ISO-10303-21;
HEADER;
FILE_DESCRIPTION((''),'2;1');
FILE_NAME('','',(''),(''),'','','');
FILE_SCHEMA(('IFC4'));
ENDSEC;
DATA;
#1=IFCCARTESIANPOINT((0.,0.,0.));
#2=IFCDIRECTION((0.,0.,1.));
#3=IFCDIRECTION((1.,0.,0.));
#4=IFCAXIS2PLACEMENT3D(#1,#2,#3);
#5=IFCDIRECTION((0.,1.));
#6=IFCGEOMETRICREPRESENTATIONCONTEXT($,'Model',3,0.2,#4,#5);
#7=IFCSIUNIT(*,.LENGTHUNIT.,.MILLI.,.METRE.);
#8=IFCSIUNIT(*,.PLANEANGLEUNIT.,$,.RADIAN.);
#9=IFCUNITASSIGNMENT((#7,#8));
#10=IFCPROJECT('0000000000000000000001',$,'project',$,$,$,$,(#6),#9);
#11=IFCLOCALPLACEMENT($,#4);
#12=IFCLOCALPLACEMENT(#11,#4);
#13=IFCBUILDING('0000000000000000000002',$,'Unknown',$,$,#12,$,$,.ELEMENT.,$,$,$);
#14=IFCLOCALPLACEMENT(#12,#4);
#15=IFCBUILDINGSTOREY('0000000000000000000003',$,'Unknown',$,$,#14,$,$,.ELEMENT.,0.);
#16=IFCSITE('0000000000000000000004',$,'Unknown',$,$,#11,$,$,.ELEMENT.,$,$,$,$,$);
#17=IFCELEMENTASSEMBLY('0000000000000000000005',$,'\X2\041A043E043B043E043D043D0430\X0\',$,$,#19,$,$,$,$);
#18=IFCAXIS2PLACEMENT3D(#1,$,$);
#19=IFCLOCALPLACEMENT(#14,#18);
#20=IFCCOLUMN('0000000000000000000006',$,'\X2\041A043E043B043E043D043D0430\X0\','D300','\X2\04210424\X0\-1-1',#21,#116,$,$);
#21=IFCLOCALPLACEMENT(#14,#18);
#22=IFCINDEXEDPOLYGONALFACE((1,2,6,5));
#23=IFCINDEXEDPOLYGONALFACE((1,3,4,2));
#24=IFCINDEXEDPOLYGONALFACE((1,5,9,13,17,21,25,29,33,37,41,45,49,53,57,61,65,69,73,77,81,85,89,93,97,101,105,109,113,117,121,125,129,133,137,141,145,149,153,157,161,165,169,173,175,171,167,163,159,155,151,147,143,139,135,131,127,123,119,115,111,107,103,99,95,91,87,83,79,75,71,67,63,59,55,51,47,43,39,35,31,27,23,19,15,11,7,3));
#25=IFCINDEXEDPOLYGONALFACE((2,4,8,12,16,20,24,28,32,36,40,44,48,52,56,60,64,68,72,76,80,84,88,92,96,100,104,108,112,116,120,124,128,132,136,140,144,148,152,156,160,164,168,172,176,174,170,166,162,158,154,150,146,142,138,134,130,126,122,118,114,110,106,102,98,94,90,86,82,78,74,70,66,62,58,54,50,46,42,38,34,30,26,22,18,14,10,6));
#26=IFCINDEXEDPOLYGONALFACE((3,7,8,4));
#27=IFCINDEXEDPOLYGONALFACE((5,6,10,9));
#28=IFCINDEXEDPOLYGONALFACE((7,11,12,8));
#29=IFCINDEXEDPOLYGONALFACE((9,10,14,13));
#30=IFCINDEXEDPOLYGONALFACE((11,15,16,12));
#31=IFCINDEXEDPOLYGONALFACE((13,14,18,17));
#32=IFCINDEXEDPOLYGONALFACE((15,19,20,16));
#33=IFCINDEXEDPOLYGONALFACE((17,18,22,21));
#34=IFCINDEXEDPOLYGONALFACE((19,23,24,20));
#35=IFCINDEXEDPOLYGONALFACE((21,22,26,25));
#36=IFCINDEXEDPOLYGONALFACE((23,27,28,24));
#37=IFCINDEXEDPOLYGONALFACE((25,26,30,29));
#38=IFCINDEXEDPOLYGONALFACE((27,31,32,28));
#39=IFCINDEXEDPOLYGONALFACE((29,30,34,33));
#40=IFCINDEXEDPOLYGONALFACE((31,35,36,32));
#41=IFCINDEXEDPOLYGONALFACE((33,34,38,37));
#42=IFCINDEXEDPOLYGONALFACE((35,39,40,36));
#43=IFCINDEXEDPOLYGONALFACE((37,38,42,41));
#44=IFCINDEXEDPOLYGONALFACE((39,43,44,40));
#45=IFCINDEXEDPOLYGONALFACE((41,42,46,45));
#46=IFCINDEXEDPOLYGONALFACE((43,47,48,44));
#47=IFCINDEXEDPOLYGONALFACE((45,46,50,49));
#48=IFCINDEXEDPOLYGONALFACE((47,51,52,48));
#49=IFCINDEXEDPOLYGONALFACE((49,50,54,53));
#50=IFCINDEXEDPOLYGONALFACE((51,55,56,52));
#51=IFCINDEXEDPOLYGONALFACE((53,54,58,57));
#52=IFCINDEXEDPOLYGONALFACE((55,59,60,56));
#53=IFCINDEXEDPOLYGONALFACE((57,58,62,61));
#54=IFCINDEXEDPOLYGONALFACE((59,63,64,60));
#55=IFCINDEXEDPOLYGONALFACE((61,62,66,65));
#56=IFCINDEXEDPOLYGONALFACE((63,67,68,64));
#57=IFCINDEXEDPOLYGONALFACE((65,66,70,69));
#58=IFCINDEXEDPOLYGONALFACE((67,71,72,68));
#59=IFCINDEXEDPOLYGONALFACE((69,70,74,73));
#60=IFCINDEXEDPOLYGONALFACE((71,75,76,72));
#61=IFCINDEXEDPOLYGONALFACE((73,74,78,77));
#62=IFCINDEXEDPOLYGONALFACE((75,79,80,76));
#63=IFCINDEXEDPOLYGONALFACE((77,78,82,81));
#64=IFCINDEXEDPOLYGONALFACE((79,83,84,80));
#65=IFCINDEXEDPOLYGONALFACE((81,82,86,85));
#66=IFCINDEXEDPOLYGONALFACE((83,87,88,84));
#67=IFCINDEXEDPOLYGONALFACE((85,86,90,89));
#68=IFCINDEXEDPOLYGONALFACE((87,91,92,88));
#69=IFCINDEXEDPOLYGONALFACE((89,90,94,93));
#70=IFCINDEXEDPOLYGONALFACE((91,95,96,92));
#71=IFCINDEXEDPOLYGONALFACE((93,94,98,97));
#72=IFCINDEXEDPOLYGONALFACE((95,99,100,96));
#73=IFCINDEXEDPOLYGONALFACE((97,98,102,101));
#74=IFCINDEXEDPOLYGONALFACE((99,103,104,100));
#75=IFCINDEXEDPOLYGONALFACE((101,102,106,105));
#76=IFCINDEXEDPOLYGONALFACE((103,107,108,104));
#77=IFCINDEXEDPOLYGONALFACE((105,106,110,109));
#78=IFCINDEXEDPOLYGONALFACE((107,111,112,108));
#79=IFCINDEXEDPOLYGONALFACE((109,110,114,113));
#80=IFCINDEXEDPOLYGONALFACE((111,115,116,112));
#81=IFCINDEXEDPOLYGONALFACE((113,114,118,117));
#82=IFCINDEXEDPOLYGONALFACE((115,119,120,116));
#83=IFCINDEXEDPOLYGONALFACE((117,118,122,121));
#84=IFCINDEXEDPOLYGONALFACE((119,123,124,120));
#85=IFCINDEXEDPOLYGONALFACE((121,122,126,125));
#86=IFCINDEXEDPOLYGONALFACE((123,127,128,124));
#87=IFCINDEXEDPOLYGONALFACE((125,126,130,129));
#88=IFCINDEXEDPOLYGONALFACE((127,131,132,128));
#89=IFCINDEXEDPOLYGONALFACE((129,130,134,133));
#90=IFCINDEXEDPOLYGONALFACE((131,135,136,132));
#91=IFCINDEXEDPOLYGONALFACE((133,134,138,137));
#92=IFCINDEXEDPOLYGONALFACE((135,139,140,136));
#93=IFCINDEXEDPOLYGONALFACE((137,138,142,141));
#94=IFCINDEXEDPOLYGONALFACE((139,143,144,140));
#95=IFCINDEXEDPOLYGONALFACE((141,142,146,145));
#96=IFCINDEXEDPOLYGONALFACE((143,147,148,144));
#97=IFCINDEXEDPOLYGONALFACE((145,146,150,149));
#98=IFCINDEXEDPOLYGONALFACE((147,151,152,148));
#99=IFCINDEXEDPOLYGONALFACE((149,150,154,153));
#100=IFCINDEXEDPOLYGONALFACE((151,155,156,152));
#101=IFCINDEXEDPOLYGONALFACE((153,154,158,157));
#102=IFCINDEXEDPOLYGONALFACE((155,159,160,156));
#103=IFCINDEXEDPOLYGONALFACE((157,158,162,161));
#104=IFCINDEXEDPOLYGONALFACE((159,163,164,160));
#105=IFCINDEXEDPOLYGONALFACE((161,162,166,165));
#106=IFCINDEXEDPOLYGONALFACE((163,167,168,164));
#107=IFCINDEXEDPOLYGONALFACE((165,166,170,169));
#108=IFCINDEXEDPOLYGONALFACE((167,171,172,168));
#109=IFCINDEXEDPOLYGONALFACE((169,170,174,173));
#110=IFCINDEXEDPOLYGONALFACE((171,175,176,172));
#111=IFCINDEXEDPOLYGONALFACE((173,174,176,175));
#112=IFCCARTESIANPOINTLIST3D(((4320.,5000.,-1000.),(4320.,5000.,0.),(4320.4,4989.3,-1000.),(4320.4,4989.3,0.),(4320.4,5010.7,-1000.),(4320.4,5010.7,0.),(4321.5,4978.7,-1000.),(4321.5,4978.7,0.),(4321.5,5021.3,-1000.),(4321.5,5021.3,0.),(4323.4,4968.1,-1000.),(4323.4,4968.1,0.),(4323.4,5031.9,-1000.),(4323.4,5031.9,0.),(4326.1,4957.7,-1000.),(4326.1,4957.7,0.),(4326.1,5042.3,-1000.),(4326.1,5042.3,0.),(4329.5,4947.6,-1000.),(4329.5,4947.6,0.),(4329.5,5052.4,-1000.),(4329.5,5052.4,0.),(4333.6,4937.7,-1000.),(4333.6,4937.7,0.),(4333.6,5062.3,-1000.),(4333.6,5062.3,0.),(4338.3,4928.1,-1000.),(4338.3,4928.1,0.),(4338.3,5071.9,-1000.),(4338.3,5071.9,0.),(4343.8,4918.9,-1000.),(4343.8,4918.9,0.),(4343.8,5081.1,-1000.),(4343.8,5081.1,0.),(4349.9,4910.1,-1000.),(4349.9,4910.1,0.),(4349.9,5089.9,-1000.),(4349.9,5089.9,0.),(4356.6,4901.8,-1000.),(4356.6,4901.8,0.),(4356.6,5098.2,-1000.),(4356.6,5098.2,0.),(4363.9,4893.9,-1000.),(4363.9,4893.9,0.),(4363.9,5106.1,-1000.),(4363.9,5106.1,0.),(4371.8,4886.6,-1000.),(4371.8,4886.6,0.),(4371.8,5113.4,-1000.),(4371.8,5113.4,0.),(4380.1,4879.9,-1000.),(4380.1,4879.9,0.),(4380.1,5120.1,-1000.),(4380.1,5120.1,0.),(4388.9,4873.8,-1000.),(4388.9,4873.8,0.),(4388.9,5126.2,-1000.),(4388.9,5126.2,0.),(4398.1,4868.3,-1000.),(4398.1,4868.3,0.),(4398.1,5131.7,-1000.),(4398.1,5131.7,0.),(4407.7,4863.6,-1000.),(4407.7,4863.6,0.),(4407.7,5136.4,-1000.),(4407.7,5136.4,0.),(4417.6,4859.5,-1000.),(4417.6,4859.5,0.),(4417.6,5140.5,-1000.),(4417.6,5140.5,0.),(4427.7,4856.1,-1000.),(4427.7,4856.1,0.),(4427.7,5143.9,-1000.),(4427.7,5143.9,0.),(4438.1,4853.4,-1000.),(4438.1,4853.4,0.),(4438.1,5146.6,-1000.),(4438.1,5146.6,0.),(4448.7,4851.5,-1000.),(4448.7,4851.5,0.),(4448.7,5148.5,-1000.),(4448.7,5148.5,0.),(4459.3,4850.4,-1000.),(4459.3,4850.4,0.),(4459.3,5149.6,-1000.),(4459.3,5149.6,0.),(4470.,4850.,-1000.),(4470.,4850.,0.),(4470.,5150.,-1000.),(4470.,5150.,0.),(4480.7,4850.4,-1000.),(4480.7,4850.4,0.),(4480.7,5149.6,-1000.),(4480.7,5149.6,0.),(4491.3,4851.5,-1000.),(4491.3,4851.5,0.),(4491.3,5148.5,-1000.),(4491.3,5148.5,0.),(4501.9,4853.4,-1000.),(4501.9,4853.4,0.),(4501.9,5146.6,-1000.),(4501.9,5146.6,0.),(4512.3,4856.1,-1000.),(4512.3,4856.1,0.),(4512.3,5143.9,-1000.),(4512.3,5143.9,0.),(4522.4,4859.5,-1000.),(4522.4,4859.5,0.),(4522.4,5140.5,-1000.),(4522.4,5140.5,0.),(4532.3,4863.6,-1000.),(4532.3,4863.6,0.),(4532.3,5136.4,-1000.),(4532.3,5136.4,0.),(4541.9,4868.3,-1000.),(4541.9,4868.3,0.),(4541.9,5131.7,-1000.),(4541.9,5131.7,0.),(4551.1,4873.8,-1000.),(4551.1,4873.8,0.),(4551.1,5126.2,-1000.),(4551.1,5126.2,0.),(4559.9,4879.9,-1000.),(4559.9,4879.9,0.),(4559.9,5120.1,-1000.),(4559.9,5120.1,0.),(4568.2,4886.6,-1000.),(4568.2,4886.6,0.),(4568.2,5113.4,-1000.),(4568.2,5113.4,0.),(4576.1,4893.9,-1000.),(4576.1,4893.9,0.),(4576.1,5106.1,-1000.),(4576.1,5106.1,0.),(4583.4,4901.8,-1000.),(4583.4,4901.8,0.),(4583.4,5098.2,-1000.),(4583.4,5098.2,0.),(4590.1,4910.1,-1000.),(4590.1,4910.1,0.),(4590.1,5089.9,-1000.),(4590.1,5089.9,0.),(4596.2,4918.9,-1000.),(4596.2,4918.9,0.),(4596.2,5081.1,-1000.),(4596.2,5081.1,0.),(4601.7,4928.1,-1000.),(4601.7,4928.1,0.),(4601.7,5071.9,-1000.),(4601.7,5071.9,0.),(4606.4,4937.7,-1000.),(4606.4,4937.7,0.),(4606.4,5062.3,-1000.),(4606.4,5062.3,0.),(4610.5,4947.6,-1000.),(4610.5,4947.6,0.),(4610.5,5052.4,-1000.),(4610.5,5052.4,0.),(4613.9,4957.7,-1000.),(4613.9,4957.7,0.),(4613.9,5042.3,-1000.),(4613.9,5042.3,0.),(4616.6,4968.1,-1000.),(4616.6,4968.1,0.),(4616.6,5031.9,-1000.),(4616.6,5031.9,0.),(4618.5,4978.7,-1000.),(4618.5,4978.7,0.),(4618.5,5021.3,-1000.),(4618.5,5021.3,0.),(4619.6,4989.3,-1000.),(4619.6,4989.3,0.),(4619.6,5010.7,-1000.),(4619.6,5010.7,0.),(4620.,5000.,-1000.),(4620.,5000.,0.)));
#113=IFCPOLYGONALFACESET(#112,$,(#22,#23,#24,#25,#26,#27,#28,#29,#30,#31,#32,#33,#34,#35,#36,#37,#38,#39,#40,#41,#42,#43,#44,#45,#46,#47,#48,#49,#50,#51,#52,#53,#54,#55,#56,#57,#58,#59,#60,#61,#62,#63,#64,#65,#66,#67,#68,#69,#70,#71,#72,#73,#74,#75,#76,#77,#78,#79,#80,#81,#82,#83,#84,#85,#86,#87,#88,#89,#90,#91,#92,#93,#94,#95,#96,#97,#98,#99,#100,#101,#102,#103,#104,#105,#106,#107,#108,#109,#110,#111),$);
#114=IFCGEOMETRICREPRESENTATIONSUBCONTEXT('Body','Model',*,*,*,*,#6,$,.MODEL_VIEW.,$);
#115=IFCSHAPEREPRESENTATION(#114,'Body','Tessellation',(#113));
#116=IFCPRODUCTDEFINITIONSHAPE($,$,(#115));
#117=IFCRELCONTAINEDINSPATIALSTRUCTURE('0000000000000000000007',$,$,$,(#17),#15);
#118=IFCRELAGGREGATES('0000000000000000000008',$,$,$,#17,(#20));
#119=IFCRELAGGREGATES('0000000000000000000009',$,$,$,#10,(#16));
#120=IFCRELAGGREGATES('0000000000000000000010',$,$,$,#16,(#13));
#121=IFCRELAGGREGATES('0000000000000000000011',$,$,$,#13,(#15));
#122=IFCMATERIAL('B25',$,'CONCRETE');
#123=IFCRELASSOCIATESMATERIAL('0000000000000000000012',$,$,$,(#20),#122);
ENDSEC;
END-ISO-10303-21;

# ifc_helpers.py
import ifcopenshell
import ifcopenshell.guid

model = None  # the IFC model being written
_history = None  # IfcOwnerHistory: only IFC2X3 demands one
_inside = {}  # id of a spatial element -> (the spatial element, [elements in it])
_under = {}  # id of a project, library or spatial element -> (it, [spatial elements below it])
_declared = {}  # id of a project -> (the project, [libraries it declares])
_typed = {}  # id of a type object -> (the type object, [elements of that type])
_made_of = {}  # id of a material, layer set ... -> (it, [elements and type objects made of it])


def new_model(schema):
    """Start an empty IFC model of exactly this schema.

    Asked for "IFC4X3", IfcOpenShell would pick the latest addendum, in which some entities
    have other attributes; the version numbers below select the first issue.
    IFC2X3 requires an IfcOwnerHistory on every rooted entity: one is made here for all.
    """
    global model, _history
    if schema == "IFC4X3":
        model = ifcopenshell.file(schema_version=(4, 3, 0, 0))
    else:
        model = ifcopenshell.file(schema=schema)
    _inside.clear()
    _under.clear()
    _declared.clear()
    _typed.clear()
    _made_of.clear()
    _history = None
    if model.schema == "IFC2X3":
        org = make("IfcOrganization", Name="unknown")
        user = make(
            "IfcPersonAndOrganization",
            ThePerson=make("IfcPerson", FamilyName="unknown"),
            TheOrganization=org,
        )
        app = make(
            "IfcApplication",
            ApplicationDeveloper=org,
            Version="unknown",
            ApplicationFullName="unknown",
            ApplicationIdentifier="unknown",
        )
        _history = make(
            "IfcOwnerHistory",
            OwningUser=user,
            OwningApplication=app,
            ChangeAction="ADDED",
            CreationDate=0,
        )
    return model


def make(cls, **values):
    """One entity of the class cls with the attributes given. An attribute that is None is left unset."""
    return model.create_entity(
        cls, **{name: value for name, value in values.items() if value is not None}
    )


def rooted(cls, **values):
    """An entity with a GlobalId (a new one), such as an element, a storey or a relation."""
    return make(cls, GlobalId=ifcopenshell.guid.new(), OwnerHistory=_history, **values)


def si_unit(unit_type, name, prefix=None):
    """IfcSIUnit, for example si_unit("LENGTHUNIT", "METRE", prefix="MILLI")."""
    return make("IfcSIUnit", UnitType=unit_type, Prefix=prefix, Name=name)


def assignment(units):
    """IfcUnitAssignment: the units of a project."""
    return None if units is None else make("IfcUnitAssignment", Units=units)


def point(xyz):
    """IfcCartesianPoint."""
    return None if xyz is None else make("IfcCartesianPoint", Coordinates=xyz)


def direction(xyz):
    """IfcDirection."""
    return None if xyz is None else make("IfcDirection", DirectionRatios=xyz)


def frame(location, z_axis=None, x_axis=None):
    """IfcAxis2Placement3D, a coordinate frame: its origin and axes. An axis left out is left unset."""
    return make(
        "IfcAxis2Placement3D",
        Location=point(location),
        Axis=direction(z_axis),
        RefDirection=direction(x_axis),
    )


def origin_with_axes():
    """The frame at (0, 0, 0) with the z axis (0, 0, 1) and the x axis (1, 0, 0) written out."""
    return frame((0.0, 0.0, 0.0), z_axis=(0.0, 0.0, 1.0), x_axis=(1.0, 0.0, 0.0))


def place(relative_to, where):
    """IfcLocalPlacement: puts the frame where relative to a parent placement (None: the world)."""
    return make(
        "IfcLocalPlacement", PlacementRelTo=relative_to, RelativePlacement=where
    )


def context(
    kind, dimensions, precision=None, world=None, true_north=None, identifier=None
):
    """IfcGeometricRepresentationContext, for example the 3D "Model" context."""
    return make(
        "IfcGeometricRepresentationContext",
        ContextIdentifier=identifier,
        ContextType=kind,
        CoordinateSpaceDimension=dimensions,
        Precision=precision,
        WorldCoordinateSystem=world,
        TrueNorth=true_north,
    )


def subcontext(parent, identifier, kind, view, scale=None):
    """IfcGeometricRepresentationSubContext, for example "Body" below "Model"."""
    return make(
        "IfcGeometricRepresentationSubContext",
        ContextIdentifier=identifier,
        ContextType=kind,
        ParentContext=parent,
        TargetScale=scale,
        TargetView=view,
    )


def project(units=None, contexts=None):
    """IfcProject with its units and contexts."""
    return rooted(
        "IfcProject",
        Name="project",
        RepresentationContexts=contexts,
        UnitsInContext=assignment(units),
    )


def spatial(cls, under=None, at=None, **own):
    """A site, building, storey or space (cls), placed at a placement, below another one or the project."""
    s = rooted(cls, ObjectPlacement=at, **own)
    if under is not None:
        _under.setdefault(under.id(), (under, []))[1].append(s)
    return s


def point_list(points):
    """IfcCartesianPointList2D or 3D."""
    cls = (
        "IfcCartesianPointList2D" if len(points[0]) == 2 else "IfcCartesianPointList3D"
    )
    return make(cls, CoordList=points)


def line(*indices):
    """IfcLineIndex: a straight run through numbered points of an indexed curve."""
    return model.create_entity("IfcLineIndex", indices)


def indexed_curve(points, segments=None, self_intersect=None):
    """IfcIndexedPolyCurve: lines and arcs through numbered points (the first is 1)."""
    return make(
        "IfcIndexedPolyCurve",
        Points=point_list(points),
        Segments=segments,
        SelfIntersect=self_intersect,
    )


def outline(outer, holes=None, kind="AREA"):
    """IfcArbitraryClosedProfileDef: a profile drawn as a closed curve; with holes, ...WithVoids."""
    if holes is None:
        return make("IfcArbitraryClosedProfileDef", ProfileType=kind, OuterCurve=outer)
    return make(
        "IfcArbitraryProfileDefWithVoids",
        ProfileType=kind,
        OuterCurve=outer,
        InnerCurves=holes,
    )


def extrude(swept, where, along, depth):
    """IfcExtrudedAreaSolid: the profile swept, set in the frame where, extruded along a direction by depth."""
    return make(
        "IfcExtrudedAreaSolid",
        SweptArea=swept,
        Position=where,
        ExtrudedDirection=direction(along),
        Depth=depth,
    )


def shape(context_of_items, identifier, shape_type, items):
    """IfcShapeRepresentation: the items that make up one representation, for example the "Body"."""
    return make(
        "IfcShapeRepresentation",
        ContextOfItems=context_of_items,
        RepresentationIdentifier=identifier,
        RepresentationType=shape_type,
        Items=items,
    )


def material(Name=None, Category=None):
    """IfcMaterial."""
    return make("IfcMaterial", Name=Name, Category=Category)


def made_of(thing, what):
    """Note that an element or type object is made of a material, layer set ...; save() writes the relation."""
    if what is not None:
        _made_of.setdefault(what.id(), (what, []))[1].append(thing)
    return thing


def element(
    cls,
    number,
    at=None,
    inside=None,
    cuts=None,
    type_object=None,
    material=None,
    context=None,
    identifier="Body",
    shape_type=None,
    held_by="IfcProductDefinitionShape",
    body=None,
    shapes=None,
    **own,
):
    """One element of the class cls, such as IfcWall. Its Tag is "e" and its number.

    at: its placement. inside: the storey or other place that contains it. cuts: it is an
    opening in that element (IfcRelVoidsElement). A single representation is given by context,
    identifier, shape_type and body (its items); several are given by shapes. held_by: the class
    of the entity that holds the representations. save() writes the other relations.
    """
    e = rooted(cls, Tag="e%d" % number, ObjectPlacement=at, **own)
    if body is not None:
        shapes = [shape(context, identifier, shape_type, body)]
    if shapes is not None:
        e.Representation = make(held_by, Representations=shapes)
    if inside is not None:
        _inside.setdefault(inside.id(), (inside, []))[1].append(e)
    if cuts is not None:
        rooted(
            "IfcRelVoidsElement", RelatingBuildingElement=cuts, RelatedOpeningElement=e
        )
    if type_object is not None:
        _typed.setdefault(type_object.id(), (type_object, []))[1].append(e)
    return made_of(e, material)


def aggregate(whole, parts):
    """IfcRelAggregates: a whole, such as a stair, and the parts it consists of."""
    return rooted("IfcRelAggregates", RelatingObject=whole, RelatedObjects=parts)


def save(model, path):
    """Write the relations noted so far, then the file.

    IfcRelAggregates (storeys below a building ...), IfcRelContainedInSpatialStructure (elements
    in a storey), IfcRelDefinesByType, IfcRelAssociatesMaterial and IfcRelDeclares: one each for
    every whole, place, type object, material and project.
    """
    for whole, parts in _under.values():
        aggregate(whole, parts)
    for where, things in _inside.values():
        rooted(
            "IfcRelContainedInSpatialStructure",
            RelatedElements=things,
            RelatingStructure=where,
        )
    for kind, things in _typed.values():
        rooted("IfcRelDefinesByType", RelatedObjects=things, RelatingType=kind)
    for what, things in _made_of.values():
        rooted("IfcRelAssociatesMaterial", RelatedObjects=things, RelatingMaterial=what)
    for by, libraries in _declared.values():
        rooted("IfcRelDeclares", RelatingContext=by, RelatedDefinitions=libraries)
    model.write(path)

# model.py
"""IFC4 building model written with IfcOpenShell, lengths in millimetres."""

from ifc_helpers import new_model, si_unit, direction, frame, origin_with_axes, place, context, subcontext, project, spatial, line, indexed_curve, outline, extrude, material, element, aggregate, save


model = new_model("IFC4")

# Units and contexts
model_context = context("Model", 3, precision=0.2, world=origin_with_axes(), true_north=direction((0.0, 1.0)))
body_context = subcontext(model_context, "Body", "Model", "MODEL_VIEW")
ifc_project = project(units=[si_unit("LENGTHUNIT", "METRE", prefix="MILLI"), si_unit("PLANEANGLEUNIT", "RADIAN")], contexts=[model_context])

# Site, building, storey
site_placement = place(None, origin_with_axes())
site = spatial("IfcSite", under=ifc_project, at=site_placement, Name="Unknown", CompositionType="ELEMENT")
building_placement = place(site_placement, origin_with_axes())
building = spatial("IfcBuilding", under=site, at=building_placement, Name="Unknown", CompositionType="ELEMENT")
storey_placement = place(building_placement, origin_with_axes())
storey = spatial("IfcBuildingStorey", under=building, at=storey_placement, Name="Unknown", CompositionType="ELEMENT", Elevation=0.0)

# Element assembly, column
placement_1 = place(storey_placement, frame((4470.0, 5000.0, -1000.0), z_axis=(-1.0, 0.0, 0.0), x_axis=(0.0, 0.0, 1.0)))
assembly_1 = element("IfcElementAssembly", 1, at=placement_1, inside=storey, Name="Колонна")
ifc_material_1 = material(Name="B25", Category="CONCRETE")
placement_2 = place(placement_1, origin_with_axes())
column_1 = element("IfcColumn", 2, at=placement_2, material=ifc_material_1, Name="Колонна", Description="D300", ObjectType="СФ-1-1", context=body_context, shape_type="SolidModel", body=[
    extrude(outline(indexed_curve([(150.0, 0.0), (149.6, 10.7), (148.5, 21.3), (146.6, 31.9), (143.9, 42.3), (140.5, 52.4), (136.4, 62.3), (131.7, 71.9), (126.2, 81.1), (120.1, 89.9), (113.4, 98.2), (106.1, 106.1), (98.2, 113.4), (89.9, 120.1), (81.1, 126.2), (71.9, 131.7), (62.3, 136.4), (52.4, 140.5), (42.3, 143.9), (31.9, 146.6), (21.3, 148.5), (10.7, 149.6), (0.0, 150.0), (-10.7, 149.6), (-21.3, 148.5), (-31.9, 146.6), (-42.3, 143.9), (-52.4, 140.5), (-62.3, 136.4), (-71.9, 131.7), (-81.1, 126.2), (-89.9, 120.1), (-98.2, 113.4), (-106.1, 106.1), (-113.4, 98.2), (-120.1, 89.9), (-126.2, 81.1), (-131.7, 71.9), (-136.4, 62.3), (-140.5, 52.4), (-143.9, 42.3), (-146.6, 31.9), (-148.5, 21.3), (-149.6, 10.7), (-150.0, 0.0), (-149.6, -10.7), (-148.5, -21.3), (-146.6, -31.9), (-143.9, -42.3), (-140.5, -52.4), (-136.4, -62.3), (-131.7, -71.9), (-126.2, -81.1), (-120.1, -89.9), (-113.4, -98.2), (-106.1, -106.1), (-98.2, -113.4), (-89.9, -120.1), (-81.1, -126.2), (-71.9, -131.7), (-62.3, -136.4), (-52.4, -140.5), (-42.3, -143.9), (-31.9, -146.6), (-21.3, -148.5), (-10.7, -149.6), (0.0, -150.0), (10.7, -149.6), (21.3, -148.5), (31.9, -146.6), (42.3, -143.9), (52.4, -140.5), (62.3, -136.4), (71.9, -131.7), (81.1, -126.2), (89.9, -120.1), (98.2, -113.4), (106.1, -106.1), (113.4, -98.2), (120.1, -89.9), (126.2, -81.1), (131.7, -71.9), (136.4, -62.3), (140.5, -52.4), (143.9, -42.3), (146.6, -31.9), (148.5, -21.3), (149.6, -10.7)], segments=[line(1, 2, 3, 4, 5, 6, 7, 8, 9, 10, 11, 12, 13, 14, 15, 16, 17, 18, 19, 20, 21, 22, 23, 24, 25, 26, 27, 28, 29, 30, 31, 32, 33, 34, 35, 36, 37, 38, 39, 40, 41, 42, 43, 44, 45, 46, 47, 48, 49, 50, 51, 52, 53, 54, 55, 56, 57, 58, 59, 60, 61, 62, 63, 64, 65, 66, 67, 68, 69, 70, 71, 72, 73, 74, 75, 76, 77, 78, 79, 80, 81, 82, 83, 84, 85, 86, 87, 88, 1)])), frame((0.0, 0.0, 0.0), z_axis=(-1.0, 0.0, 0.0), x_axis=(0.0, 0.0, 1.0)), (0.0, 0.0, -1.0), 1000.0),
])
aggregate(assembly_1, [column_1])

save(model, "model.ifc")
